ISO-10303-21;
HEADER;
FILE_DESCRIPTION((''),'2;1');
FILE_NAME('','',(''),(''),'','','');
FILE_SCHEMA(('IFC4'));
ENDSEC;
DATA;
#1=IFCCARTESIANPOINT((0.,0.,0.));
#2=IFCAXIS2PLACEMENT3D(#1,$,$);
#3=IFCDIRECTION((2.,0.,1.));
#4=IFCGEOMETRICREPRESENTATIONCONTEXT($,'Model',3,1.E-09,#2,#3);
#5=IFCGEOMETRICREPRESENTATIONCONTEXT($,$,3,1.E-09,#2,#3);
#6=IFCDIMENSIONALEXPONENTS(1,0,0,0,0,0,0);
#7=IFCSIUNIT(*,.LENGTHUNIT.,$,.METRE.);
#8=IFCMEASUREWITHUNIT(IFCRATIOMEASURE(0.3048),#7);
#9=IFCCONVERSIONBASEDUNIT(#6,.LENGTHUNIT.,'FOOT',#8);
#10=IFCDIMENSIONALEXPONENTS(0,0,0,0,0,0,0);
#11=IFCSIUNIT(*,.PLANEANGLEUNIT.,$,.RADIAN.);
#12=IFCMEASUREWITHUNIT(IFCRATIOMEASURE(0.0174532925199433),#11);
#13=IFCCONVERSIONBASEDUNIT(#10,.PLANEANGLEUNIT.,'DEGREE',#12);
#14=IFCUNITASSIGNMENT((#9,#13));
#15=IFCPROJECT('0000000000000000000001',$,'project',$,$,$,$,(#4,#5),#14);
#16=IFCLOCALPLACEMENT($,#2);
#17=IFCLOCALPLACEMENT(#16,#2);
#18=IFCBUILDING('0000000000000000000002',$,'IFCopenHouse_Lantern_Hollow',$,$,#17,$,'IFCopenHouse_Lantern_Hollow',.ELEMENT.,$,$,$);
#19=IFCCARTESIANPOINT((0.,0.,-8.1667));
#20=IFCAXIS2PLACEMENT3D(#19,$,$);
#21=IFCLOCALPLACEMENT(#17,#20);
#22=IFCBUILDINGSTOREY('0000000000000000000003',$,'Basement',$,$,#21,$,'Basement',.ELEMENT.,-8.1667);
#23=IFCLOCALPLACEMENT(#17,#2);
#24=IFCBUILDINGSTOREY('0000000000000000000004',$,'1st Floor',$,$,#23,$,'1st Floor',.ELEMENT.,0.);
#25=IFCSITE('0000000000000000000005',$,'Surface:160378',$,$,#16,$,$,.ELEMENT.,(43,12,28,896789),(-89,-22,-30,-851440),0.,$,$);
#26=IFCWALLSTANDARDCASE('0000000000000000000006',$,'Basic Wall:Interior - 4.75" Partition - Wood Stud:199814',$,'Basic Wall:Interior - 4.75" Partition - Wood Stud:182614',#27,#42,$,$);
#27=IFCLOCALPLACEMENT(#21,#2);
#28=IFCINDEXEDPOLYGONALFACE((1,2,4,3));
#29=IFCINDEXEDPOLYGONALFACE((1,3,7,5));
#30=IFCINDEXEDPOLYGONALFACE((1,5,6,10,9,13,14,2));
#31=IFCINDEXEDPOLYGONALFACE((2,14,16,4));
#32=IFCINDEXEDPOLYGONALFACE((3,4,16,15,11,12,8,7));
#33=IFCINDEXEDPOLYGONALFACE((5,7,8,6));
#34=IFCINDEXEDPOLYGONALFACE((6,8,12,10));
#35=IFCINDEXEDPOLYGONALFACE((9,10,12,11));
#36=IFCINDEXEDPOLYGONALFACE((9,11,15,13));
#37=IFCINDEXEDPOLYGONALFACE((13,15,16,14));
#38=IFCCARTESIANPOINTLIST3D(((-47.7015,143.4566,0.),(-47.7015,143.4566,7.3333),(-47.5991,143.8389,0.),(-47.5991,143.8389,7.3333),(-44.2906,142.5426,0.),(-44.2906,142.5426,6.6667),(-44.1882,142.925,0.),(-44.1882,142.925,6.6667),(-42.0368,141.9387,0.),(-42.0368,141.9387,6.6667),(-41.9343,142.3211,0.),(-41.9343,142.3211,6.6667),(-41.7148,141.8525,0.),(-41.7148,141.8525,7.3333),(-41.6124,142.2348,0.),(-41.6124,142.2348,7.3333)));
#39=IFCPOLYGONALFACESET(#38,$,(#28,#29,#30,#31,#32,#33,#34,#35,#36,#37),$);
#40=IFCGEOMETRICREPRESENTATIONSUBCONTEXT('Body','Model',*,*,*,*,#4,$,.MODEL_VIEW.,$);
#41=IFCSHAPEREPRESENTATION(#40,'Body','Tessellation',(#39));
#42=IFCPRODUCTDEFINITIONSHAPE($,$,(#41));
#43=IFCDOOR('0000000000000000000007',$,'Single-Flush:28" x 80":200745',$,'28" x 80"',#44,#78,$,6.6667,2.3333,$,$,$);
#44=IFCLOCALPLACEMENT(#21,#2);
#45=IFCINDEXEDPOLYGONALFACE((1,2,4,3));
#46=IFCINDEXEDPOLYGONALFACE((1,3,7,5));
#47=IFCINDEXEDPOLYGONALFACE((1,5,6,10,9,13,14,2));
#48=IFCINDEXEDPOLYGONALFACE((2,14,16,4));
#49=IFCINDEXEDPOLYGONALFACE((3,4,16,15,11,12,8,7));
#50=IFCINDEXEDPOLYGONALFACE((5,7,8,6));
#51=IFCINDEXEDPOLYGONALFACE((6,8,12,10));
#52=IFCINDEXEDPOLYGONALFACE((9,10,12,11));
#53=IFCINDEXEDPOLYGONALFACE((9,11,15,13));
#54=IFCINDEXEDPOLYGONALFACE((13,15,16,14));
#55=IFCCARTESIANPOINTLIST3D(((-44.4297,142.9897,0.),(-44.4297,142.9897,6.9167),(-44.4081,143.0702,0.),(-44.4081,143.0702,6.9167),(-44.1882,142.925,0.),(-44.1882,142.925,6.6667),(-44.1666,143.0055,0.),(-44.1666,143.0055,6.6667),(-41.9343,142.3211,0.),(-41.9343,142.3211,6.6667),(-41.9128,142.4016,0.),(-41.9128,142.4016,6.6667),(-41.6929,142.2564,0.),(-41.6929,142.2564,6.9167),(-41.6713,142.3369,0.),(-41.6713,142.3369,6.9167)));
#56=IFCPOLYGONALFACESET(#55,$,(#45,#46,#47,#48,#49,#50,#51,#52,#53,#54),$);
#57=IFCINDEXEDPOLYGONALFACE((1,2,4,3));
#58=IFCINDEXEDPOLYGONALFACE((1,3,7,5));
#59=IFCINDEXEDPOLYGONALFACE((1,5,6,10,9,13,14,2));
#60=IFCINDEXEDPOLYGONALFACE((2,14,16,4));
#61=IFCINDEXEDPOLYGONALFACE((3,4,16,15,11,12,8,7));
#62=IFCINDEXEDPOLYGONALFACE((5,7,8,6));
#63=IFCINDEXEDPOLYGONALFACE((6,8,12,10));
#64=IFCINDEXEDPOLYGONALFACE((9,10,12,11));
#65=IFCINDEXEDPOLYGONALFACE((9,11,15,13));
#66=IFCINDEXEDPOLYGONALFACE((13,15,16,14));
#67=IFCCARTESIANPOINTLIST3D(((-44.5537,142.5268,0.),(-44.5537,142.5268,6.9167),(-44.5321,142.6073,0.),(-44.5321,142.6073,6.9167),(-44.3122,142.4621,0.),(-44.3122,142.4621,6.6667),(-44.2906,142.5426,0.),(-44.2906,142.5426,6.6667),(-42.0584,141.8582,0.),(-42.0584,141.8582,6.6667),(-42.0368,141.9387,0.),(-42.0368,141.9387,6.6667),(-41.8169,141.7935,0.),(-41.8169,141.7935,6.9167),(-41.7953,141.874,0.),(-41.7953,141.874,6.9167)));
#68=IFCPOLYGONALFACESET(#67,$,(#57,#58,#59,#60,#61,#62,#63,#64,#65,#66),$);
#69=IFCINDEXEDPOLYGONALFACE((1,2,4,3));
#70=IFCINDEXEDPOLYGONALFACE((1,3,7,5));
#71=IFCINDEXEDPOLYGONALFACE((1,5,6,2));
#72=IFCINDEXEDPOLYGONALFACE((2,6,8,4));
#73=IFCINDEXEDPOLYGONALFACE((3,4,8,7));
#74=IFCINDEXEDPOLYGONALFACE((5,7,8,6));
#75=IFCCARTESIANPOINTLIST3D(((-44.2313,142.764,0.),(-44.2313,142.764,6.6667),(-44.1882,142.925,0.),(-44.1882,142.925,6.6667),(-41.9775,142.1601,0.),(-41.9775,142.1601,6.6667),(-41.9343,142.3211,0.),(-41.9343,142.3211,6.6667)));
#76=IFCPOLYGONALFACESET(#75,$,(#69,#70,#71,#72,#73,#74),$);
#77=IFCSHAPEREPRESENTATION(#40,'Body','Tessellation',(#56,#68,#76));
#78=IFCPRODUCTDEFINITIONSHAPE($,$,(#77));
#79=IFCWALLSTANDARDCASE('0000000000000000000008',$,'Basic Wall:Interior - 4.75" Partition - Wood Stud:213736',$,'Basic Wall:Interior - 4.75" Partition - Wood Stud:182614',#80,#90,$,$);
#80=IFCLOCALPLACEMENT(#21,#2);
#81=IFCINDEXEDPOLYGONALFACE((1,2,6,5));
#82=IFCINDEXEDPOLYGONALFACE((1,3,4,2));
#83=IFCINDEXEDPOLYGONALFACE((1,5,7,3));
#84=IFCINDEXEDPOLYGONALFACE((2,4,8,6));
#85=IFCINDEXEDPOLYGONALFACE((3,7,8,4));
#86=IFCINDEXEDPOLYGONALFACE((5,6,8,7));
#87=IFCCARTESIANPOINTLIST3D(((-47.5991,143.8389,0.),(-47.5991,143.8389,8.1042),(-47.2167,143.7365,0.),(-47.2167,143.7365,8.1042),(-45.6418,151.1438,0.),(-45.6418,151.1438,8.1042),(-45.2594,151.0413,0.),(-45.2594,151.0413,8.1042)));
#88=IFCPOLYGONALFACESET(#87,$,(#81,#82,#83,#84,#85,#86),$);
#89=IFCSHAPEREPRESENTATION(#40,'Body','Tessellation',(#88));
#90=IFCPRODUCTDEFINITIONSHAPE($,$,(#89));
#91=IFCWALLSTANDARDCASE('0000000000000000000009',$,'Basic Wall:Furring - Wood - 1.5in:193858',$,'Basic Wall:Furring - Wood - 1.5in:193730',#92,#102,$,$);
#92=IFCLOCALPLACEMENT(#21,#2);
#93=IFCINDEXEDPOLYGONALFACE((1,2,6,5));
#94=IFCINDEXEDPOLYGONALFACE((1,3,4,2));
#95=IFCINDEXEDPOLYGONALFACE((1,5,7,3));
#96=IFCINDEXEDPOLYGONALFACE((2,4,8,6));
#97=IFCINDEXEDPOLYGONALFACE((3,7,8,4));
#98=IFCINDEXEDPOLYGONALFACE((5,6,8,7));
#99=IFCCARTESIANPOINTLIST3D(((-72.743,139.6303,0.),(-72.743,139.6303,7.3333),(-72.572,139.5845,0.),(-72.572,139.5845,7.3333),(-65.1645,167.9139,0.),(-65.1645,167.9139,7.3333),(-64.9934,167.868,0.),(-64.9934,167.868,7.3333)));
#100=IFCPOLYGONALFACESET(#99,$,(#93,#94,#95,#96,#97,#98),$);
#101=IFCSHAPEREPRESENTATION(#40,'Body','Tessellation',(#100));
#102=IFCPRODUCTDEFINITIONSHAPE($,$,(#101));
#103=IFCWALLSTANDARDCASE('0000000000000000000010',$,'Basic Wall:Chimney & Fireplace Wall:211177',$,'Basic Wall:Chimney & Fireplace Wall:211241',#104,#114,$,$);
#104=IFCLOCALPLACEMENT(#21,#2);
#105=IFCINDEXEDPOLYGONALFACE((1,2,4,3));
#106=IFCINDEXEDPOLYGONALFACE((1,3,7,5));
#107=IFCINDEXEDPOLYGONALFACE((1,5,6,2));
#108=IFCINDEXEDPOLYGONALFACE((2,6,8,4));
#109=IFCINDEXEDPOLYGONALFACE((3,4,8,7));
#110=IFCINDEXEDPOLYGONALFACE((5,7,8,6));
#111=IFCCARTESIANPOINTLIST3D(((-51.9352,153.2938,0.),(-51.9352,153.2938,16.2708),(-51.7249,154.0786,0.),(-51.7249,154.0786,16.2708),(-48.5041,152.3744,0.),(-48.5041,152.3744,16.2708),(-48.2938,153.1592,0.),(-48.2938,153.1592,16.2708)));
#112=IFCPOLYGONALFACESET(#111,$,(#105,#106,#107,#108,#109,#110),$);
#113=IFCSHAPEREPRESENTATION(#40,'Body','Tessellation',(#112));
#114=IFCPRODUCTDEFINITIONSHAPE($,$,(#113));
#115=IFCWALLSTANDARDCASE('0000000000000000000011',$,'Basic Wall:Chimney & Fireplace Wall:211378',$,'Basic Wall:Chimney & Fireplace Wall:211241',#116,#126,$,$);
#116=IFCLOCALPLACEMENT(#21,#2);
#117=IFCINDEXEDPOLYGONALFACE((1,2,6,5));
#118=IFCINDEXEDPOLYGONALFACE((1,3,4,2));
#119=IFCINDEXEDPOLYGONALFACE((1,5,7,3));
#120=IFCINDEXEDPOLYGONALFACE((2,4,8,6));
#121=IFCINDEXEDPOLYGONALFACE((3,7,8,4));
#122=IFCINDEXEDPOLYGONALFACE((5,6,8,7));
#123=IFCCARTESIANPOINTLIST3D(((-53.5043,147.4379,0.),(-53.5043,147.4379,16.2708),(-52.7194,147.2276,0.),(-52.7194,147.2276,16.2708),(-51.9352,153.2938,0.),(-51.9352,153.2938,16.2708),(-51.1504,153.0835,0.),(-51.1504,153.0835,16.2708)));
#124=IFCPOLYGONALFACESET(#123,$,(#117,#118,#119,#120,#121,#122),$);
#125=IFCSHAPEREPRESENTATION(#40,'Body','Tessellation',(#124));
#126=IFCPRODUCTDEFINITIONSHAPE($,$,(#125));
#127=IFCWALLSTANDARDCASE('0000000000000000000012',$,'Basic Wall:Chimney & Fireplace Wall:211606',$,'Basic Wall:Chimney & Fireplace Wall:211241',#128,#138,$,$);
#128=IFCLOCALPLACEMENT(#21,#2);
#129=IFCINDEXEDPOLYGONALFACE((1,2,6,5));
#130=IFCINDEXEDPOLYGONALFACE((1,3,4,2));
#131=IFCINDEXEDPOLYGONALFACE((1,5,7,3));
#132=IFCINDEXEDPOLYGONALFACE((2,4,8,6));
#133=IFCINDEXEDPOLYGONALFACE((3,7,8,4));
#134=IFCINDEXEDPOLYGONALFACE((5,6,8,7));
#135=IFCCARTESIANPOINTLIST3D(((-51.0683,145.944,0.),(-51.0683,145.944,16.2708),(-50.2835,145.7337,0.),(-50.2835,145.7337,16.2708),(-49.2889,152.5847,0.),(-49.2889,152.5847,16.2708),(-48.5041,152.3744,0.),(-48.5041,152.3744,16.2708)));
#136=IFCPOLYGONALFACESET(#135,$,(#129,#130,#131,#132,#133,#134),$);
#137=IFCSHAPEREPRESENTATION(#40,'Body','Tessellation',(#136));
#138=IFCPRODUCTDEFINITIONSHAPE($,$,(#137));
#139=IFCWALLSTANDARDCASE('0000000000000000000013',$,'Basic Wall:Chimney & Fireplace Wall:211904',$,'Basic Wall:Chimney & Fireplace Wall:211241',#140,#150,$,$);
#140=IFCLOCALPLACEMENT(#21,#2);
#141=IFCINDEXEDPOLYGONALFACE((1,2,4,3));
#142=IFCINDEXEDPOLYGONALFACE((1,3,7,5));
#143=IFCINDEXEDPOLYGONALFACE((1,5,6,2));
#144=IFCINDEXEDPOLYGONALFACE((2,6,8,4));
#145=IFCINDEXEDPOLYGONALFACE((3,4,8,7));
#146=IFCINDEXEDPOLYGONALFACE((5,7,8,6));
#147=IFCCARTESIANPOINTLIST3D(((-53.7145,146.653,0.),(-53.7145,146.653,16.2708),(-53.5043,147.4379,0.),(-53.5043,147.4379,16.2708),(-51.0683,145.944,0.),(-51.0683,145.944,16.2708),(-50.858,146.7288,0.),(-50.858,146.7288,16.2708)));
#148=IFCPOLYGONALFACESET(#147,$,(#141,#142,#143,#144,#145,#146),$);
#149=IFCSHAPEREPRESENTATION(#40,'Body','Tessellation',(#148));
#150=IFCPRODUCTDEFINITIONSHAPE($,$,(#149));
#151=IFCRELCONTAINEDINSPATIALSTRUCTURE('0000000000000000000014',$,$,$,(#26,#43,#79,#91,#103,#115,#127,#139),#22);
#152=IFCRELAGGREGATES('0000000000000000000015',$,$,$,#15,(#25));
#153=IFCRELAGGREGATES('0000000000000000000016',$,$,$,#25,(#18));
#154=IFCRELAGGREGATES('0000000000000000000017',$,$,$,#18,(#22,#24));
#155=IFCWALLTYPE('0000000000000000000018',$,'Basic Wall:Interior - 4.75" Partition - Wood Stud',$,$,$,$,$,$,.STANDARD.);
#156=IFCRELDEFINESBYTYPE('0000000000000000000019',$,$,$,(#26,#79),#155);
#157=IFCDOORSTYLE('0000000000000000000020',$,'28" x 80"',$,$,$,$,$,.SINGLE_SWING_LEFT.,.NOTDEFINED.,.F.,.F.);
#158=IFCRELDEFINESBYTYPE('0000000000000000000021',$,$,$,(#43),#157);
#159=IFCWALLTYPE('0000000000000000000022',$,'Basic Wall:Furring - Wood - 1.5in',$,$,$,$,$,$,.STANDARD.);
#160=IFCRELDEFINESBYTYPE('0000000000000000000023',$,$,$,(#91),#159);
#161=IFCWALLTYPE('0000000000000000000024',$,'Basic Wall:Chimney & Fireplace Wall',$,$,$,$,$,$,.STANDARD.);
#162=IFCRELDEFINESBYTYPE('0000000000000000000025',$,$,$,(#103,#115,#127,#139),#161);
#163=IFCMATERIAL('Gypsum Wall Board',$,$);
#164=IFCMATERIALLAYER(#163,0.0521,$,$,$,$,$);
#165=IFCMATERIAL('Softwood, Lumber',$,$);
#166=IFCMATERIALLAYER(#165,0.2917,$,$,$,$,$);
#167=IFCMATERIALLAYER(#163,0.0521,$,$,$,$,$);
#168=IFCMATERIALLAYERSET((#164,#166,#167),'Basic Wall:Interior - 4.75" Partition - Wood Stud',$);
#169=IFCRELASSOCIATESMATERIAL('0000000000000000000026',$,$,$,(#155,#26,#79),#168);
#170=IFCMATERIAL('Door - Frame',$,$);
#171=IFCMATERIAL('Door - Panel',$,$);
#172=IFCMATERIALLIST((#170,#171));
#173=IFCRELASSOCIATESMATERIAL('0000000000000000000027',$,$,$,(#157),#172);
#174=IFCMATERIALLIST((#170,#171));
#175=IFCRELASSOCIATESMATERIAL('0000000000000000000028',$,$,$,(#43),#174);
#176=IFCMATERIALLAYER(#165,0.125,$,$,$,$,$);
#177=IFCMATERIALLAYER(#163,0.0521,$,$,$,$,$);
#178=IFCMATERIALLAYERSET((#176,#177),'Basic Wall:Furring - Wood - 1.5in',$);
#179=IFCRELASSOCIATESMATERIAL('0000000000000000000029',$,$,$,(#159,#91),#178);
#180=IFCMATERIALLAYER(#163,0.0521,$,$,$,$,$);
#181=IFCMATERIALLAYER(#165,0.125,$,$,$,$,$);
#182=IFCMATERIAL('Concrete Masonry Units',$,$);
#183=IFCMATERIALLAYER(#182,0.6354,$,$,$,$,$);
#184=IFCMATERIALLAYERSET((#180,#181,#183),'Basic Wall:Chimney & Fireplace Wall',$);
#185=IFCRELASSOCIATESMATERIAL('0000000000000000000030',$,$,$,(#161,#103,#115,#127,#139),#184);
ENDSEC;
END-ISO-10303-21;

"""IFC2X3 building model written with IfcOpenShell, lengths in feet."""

from ifc_helpers import new_model, entity, si_unit, converted_unit, direction, frame, frame_2d, origin, origin_2d_with_axis, place, context, subcontext, project, spatial, polyline, rectangle, outline, extrude, source, transform, mapped, material, material_list, layer, layer_set, layer_usage, type_object, type_shapes, element, fill, save


model = new_model("IFC2X3")

# Units and contexts
model_context = context("Model", 3, precision=1e-09, world=origin(), true_north=direction((2.0, 0.0, 1.0)))
context_of_model = context(None, 3, precision=1e-09, world=origin(), true_north=direction((2.0, 0.0, 1.0)))
body_context = subcontext(model_context, "Body", "Model", "MODEL_VIEW")
ifc_project = project(units=[converted_unit("LENGTHUNIT", "FOOT", entity("IfcRatioMeasure", 0.3048), si_unit("LENGTHUNIT", "METRE"), dimensions=[1, 0, 0, 0, 0, 0, 0]), converted_unit("PLANEANGLEUNIT", "DEGREE", entity("IfcRatioMeasure", 0.0174532925199433), si_unit("PLANEANGLEUNIT", "RADIAN"), dimensions=[0, 0, 0, 0, 0, 0, 0])], contexts=[model_context, context_of_model])

# Site, building, storey
site_placement = place(None, origin())
site = spatial("IfcSite", under=ifc_project, at=site_placement, Name="Surface:160378", CompositionType="ELEMENT", RefLatitude=(43, 12, 28, 896789), RefLongitude=(-89, -22, -30, -851440), RefElevation=0.0)
building_placement = place(site_placement, origin())
building = spatial("IfcBuilding", under=site, at=building_placement, Name="IFCopenHouse_Lantern_Hollow", LongName="IFCopenHouse_Lantern_Hollow", CompositionType="ELEMENT")
storey_1_placement = place(building_placement, frame((0.0, 0.0, -8.1667)))
storey_1 = spatial("IfcBuildingStorey", under=building, at=storey_1_placement, Name="Basement", LongName="Basement", CompositionType="ELEMENT", Elevation=-8.1667)

# Shared definitions
ifc_material_1 = material(Name="Concrete Masonry Units")
ifc_material_2 = material(Name="Softwood, Lumber")
ifc_material_3 = material(Name="Gypsum Wall Board")
ifc_material_4 = material(Name="Door - Frame")
ifc_material_5 = material(Name="Door - Panel")

# Shared definitions
ifc_layer_1 = layer(ifc_material_3, 0.0521)
ifc_layer_2 = layer(ifc_material_2, 0.2917)
ifc_layer_3 = layer(ifc_material_3, 0.0521)
ifc_layer_set_1 = layer_set([ifc_layer_1, ifc_layer_2, ifc_layer_3], Name="Basic Wall:Interior - 4.75\" Partition - Wood Stud")
wall_type_1 = type_object("IfcWallType", Name="Basic Wall:Interior - 4.75\" Partition - Wood Stud", PredefinedType="STANDARD", material=ifc_layer_set_1)

# Wall, opening, door
ifc_layer_usage_1 = layer_usage(ifc_layer_set_1, "AXIS2", "NEGATIVE", 0.1979)
wall_1_placement = place(storey_1_placement, frame((-47.6503, 143.6478, 0.0), z_axis=(0.0, 0.0, 1.0), x_axis=(0.965926, -0.258819, 0.0)))
wall_1 = element("IfcWallStandardCase", 1, at=wall_1_placement, inside=storey_1, type_object=wall_type_1, material=ifc_layer_usage_1, Name="Basic Wall:Interior - 4.75\" Partition - Wood Stud:199814", ObjectType="Basic Wall:Interior - 4.75\" Partition - Wood Stud:182614", context=body_context, shape_type="SweptSolid", body=[
    extrude(rectangle(XDim=6.1979, YDim=0.3958, at=frame_2d((3.099, 0.0), x_axis=(-1.0, 0.0))), origin(), (0.0, 0.0, 1.0), 7.3333),
])
opening_1_placement = place(wall_1_placement, frame((3.5312, -0.1979, 0.0)))
opening_1 = element("IfcOpeningElement", 2, at=opening_1_placement, cuts=wall_1, ObjectType="Opening", context=body_context, shape_type="SweptSolid", body=[
    extrude(rectangle(XDim=2.3333, YDim=6.6667, at=frame_2d((3.3333, 1.1667), x_axis=(0.0, -1.0))), frame((0.0, 0.0, 0.0), z_axis=(0.0, 1.0, 0.0), x_axis=(0.0, 0.0, 1.0)), (0.0, 0.0, 1.0), 0.3958),
])
ifc_material_list_1 = material_list([ifc_material_4, ifc_material_5])
ifc_material_list_2 = material_list([ifc_material_4, ifc_material_5])
door_style_1 = type_object("IfcDoorStyle", Name="28\" x 80\"", ConstructionType="NOTDEFINED", OperationType="SINGLE_SWING_LEFT", ParameterTakesPrecedence=False, Sizeable=False, material=ifc_material_list_2)
shared_shape_1 = source(origin(), body_context, "Body", "SweptSolid", [
    extrude(outline(polyline([(-1.4167, -3.5208), (1.4167, -3.5208), (1.4167, 3.3958), (1.1667, 3.3958), (1.1667, -3.2708), (-1.1667, -3.2708), (-1.1667, 3.3958), (-1.4167, 3.3958), (-1.4167, -3.5208)])), frame((1.1667, 0.4792, 3.3958), z_axis=(0.0, -1.0, 0.0), x_axis=(-1.0, 0.0, 0.0)), (0.0, 0.0, 1.0), 0.0833),
    extrude(outline(polyline([(-3.5208, -1.4167), (3.3958, -1.4167), (3.3958, -1.1667), (-3.2708, -1.1667), (-3.2708, 1.1667), (3.3958, 1.1667), (3.3958, 1.4167), (-3.5208, 1.4167), (-3.5208, -1.4167)])), frame((1.1667, 0.0, 3.3958), z_axis=(0.0, -1.0, 0.0), x_axis=(0.0, 0.0, -1.0)), (0.0, 0.0, 1.0), 0.0833),
    extrude(rectangle(XDim=2.3333, YDim=0.1667, at=origin_2d_with_axis()), frame((1.1667, 0.3125, 0.0)), (0.0, 0.0, 1.0), 6.6667),
])
type_shapes(door_style_1, [shared_shape_1])
door_1_placement = place(storey_1_placement, frame((-44.2906, 142.5426, 0.0), z_axis=(0.0, 0.0, 1.0), x_axis=(0.965926, -0.258819, 0.0)))
door_1 = element("IfcDoor", 3, at=door_1_placement, inside=storey_1, type_object=door_style_1, material=ifc_material_list_1, Name="Single-Flush:28\" x 80\":200745", ObjectType="28\" x 80\"", OverallHeight=6.6667, OverallWidth=2.3333, context=body_context, shape_type="MappedRepresentation", body=[
    mapped(shared_shape_1, transform((0.0, 0.0, 0.0), scale=1.0)),
])
fill(opening_1, door_1)

# Walls
ifc_layer_usage_2 = layer_usage(ifc_layer_set_1, "AXIS2", "NEGATIVE", 0.1979)
wall_2_placement = place(storey_1_placement, frame((-47.4079, 143.7877, 0.0), z_axis=(0.0, 0.0, 1.0), x_axis=(0.258819, 0.965926, 0.0)))
element("IfcWallStandardCase", 4, at=wall_2_placement, inside=storey_1, type_object=wall_type_1, material=ifc_layer_usage_2, Name="Basic Wall:Interior - 4.75\" Partition - Wood Stud:213736", ObjectType="Basic Wall:Interior - 4.75\" Partition - Wood Stud:182614", context=body_context, shape_type="SweptSolid", body=[
    extrude(rectangle(XDim=7.5625, YDim=0.3958, at=frame_2d((3.7813, 0.0), x_axis=(-1.0, 0.0))), origin(), (0.0, 0.0, 1.0), 8.1042),
])
ifc_layer_4 = layer(ifc_material_2, 0.125)
ifc_layer_5 = layer(ifc_material_3, 0.0521)
ifc_layer_set_2 = layer_set([ifc_layer_4, ifc_layer_5], Name="Basic Wall:Furring - Wood - 1.5in")
ifc_layer_usage_3 = layer_usage(ifc_layer_set_2, "AXIS2", "POSITIVE", -0.0885)
wall_type_2 = type_object("IfcWallType", Name="Basic Wall:Furring - Wood - 1.5in", PredefinedType="STANDARD", material=ifc_layer_set_2)
wall_3_placement = place(storey_1_placement, frame((-65.079, 167.8909, 0.0), z_axis=(0.0, 0.0, 1.0), x_axis=(-0.258819, -0.965926, 0.0)))
element("IfcWallStandardCase", 5, at=wall_3_placement, inside=storey_1, type_object=wall_type_2, material=ifc_layer_usage_3, Name="Basic Wall:Furring - Wood - 1.5in:193858", ObjectType="Basic Wall:Furring - Wood - 1.5in:193730", context=body_context, shape_type="SweptSolid", body=[
    extrude(rectangle(XDim=29.2812, YDim=0.1771, at=frame_2d((14.6406, 0.0), x_axis=(-1.0, 0.0))), origin(), (0.0, 0.0, 1.0), 7.3333),
])

# Shared definitions
storey_2_placement = place(building_placement, origin())
storey_2 = spatial("IfcBuildingStorey", under=building, at=storey_2_placement, Name="1st Floor", LongName="1st Floor", CompositionType="ELEMENT", Elevation=0.0)

# Walls
ifc_layer_6 = layer(ifc_material_3, 0.0521)
ifc_layer_7 = layer(ifc_material_2, 0.125)
ifc_layer_8 = layer(ifc_material_1, 0.6354)
ifc_layer_set_3 = layer_set([ifc_layer_6, ifc_layer_7, ifc_layer_8], Name="Basic Wall:Chimney & Fireplace Wall")
ifc_layer_usage_4 = layer_usage(ifc_layer_set_3, "AXIS2", "NEGATIVE", 0.4062)
wall_type_3 = type_object("IfcWallType", Name="Basic Wall:Chimney & Fireplace Wall", PredefinedType="STANDARD", material=ifc_layer_set_3)
wall_4_placement = place(storey_1_placement, frame((-51.83, 153.6862, 0.0), z_axis=(0.0, 0.0, 1.0), x_axis=(0.965926, -0.258819, 0.0)))
element("IfcWallStandardCase", 6, at=wall_4_placement, inside=storey_1, type_object=wall_type_3, material=ifc_layer_usage_4, Name="Basic Wall:Chimney & Fireplace Wall:211177", ObjectType="Basic Wall:Chimney & Fireplace Wall:211241", context=body_context, shape_type="SweptSolid", body=[
    extrude(rectangle(XDim=3.5521, YDim=0.8125, at=frame_2d((1.776, 0.0), x_axis=(-1.0, 0.0))), origin(), (0.0, 0.0, 1.0), 16.2708),
])
ifc_layer_usage_5 = layer_usage(ifc_layer_set_3, "AXIS2", "NEGATIVE", 0.4062)
wall_5_placement = place(storey_1_placement, frame((-53.1118, 147.3327, 0.0), z_axis=(0.0, 0.0, 1.0), x_axis=(0.258819, 0.965926, 0.0)))
element("IfcWallStandardCase", 7, at=wall_5_placement, inside=storey_1, type_object=wall_type_3, material=ifc_layer_usage_5, Name="Basic Wall:Chimney & Fireplace Wall:211378", ObjectType="Basic Wall:Chimney & Fireplace Wall:211241", context=body_context, shape_type="SweptSolid", body=[
    extrude(rectangle(XDim=6.0625, YDim=0.8125, at=frame_2d((3.0313, 0.0), x_axis=(-1.0, 0.0))), origin(), (0.0, 0.0, 1.0), 16.2708),
])
ifc_layer_usage_6 = layer_usage(ifc_layer_set_3, "AXIS2", "NEGATIVE", 0.4062)
wall_6_placement = place(storey_1_placement, frame((-48.8965, 152.4796, 0.0), z_axis=(0.0, 0.0, 1.0), x_axis=(-0.258819, -0.965926, 0.0)))
element("IfcWallStandardCase", 8, at=wall_6_placement, inside=storey_1, type_object=wall_type_3, material=ifc_layer_usage_6, Name="Basic Wall:Chimney & Fireplace Wall:211606", ObjectType="Basic Wall:Chimney & Fireplace Wall:211241", context=body_context, shape_type="SweptSolid", body=[
    extrude(rectangle(XDim=6.875, YDim=0.8125, at=frame_2d((3.4375, 0.0), x_axis=(-1.0, 0.0))), origin(), (0.0, 0.0, 1.0), 16.2708),
])
ifc_layer_usage_7 = layer_usage(ifc_layer_set_3, "AXIS2", "POSITIVE", -0.4062)
wall_7_placement = place(storey_1_placement, frame((-53.6094, 147.0454, 0.0), z_axis=(0.0, 0.0, 1.0), x_axis=(0.965926, -0.258819, 0.0)))
element("IfcWallStandardCase", 9, at=wall_7_placement, inside=storey_1, type_object=wall_type_3, material=ifc_layer_usage_7, Name="Basic Wall:Chimney & Fireplace Wall:211904", ObjectType="Basic Wall:Chimney & Fireplace Wall:211241", context=body_context, shape_type="SweptSolid", body=[
    extrude(rectangle(XDim=2.7396, YDim=0.8125, at=frame_2d((1.3698, 0.0), x_axis=(-1.0, 0.0))), origin(), (0.0, 0.0, 1.0), 16.2708),
])

save(model, "model.ifc")
